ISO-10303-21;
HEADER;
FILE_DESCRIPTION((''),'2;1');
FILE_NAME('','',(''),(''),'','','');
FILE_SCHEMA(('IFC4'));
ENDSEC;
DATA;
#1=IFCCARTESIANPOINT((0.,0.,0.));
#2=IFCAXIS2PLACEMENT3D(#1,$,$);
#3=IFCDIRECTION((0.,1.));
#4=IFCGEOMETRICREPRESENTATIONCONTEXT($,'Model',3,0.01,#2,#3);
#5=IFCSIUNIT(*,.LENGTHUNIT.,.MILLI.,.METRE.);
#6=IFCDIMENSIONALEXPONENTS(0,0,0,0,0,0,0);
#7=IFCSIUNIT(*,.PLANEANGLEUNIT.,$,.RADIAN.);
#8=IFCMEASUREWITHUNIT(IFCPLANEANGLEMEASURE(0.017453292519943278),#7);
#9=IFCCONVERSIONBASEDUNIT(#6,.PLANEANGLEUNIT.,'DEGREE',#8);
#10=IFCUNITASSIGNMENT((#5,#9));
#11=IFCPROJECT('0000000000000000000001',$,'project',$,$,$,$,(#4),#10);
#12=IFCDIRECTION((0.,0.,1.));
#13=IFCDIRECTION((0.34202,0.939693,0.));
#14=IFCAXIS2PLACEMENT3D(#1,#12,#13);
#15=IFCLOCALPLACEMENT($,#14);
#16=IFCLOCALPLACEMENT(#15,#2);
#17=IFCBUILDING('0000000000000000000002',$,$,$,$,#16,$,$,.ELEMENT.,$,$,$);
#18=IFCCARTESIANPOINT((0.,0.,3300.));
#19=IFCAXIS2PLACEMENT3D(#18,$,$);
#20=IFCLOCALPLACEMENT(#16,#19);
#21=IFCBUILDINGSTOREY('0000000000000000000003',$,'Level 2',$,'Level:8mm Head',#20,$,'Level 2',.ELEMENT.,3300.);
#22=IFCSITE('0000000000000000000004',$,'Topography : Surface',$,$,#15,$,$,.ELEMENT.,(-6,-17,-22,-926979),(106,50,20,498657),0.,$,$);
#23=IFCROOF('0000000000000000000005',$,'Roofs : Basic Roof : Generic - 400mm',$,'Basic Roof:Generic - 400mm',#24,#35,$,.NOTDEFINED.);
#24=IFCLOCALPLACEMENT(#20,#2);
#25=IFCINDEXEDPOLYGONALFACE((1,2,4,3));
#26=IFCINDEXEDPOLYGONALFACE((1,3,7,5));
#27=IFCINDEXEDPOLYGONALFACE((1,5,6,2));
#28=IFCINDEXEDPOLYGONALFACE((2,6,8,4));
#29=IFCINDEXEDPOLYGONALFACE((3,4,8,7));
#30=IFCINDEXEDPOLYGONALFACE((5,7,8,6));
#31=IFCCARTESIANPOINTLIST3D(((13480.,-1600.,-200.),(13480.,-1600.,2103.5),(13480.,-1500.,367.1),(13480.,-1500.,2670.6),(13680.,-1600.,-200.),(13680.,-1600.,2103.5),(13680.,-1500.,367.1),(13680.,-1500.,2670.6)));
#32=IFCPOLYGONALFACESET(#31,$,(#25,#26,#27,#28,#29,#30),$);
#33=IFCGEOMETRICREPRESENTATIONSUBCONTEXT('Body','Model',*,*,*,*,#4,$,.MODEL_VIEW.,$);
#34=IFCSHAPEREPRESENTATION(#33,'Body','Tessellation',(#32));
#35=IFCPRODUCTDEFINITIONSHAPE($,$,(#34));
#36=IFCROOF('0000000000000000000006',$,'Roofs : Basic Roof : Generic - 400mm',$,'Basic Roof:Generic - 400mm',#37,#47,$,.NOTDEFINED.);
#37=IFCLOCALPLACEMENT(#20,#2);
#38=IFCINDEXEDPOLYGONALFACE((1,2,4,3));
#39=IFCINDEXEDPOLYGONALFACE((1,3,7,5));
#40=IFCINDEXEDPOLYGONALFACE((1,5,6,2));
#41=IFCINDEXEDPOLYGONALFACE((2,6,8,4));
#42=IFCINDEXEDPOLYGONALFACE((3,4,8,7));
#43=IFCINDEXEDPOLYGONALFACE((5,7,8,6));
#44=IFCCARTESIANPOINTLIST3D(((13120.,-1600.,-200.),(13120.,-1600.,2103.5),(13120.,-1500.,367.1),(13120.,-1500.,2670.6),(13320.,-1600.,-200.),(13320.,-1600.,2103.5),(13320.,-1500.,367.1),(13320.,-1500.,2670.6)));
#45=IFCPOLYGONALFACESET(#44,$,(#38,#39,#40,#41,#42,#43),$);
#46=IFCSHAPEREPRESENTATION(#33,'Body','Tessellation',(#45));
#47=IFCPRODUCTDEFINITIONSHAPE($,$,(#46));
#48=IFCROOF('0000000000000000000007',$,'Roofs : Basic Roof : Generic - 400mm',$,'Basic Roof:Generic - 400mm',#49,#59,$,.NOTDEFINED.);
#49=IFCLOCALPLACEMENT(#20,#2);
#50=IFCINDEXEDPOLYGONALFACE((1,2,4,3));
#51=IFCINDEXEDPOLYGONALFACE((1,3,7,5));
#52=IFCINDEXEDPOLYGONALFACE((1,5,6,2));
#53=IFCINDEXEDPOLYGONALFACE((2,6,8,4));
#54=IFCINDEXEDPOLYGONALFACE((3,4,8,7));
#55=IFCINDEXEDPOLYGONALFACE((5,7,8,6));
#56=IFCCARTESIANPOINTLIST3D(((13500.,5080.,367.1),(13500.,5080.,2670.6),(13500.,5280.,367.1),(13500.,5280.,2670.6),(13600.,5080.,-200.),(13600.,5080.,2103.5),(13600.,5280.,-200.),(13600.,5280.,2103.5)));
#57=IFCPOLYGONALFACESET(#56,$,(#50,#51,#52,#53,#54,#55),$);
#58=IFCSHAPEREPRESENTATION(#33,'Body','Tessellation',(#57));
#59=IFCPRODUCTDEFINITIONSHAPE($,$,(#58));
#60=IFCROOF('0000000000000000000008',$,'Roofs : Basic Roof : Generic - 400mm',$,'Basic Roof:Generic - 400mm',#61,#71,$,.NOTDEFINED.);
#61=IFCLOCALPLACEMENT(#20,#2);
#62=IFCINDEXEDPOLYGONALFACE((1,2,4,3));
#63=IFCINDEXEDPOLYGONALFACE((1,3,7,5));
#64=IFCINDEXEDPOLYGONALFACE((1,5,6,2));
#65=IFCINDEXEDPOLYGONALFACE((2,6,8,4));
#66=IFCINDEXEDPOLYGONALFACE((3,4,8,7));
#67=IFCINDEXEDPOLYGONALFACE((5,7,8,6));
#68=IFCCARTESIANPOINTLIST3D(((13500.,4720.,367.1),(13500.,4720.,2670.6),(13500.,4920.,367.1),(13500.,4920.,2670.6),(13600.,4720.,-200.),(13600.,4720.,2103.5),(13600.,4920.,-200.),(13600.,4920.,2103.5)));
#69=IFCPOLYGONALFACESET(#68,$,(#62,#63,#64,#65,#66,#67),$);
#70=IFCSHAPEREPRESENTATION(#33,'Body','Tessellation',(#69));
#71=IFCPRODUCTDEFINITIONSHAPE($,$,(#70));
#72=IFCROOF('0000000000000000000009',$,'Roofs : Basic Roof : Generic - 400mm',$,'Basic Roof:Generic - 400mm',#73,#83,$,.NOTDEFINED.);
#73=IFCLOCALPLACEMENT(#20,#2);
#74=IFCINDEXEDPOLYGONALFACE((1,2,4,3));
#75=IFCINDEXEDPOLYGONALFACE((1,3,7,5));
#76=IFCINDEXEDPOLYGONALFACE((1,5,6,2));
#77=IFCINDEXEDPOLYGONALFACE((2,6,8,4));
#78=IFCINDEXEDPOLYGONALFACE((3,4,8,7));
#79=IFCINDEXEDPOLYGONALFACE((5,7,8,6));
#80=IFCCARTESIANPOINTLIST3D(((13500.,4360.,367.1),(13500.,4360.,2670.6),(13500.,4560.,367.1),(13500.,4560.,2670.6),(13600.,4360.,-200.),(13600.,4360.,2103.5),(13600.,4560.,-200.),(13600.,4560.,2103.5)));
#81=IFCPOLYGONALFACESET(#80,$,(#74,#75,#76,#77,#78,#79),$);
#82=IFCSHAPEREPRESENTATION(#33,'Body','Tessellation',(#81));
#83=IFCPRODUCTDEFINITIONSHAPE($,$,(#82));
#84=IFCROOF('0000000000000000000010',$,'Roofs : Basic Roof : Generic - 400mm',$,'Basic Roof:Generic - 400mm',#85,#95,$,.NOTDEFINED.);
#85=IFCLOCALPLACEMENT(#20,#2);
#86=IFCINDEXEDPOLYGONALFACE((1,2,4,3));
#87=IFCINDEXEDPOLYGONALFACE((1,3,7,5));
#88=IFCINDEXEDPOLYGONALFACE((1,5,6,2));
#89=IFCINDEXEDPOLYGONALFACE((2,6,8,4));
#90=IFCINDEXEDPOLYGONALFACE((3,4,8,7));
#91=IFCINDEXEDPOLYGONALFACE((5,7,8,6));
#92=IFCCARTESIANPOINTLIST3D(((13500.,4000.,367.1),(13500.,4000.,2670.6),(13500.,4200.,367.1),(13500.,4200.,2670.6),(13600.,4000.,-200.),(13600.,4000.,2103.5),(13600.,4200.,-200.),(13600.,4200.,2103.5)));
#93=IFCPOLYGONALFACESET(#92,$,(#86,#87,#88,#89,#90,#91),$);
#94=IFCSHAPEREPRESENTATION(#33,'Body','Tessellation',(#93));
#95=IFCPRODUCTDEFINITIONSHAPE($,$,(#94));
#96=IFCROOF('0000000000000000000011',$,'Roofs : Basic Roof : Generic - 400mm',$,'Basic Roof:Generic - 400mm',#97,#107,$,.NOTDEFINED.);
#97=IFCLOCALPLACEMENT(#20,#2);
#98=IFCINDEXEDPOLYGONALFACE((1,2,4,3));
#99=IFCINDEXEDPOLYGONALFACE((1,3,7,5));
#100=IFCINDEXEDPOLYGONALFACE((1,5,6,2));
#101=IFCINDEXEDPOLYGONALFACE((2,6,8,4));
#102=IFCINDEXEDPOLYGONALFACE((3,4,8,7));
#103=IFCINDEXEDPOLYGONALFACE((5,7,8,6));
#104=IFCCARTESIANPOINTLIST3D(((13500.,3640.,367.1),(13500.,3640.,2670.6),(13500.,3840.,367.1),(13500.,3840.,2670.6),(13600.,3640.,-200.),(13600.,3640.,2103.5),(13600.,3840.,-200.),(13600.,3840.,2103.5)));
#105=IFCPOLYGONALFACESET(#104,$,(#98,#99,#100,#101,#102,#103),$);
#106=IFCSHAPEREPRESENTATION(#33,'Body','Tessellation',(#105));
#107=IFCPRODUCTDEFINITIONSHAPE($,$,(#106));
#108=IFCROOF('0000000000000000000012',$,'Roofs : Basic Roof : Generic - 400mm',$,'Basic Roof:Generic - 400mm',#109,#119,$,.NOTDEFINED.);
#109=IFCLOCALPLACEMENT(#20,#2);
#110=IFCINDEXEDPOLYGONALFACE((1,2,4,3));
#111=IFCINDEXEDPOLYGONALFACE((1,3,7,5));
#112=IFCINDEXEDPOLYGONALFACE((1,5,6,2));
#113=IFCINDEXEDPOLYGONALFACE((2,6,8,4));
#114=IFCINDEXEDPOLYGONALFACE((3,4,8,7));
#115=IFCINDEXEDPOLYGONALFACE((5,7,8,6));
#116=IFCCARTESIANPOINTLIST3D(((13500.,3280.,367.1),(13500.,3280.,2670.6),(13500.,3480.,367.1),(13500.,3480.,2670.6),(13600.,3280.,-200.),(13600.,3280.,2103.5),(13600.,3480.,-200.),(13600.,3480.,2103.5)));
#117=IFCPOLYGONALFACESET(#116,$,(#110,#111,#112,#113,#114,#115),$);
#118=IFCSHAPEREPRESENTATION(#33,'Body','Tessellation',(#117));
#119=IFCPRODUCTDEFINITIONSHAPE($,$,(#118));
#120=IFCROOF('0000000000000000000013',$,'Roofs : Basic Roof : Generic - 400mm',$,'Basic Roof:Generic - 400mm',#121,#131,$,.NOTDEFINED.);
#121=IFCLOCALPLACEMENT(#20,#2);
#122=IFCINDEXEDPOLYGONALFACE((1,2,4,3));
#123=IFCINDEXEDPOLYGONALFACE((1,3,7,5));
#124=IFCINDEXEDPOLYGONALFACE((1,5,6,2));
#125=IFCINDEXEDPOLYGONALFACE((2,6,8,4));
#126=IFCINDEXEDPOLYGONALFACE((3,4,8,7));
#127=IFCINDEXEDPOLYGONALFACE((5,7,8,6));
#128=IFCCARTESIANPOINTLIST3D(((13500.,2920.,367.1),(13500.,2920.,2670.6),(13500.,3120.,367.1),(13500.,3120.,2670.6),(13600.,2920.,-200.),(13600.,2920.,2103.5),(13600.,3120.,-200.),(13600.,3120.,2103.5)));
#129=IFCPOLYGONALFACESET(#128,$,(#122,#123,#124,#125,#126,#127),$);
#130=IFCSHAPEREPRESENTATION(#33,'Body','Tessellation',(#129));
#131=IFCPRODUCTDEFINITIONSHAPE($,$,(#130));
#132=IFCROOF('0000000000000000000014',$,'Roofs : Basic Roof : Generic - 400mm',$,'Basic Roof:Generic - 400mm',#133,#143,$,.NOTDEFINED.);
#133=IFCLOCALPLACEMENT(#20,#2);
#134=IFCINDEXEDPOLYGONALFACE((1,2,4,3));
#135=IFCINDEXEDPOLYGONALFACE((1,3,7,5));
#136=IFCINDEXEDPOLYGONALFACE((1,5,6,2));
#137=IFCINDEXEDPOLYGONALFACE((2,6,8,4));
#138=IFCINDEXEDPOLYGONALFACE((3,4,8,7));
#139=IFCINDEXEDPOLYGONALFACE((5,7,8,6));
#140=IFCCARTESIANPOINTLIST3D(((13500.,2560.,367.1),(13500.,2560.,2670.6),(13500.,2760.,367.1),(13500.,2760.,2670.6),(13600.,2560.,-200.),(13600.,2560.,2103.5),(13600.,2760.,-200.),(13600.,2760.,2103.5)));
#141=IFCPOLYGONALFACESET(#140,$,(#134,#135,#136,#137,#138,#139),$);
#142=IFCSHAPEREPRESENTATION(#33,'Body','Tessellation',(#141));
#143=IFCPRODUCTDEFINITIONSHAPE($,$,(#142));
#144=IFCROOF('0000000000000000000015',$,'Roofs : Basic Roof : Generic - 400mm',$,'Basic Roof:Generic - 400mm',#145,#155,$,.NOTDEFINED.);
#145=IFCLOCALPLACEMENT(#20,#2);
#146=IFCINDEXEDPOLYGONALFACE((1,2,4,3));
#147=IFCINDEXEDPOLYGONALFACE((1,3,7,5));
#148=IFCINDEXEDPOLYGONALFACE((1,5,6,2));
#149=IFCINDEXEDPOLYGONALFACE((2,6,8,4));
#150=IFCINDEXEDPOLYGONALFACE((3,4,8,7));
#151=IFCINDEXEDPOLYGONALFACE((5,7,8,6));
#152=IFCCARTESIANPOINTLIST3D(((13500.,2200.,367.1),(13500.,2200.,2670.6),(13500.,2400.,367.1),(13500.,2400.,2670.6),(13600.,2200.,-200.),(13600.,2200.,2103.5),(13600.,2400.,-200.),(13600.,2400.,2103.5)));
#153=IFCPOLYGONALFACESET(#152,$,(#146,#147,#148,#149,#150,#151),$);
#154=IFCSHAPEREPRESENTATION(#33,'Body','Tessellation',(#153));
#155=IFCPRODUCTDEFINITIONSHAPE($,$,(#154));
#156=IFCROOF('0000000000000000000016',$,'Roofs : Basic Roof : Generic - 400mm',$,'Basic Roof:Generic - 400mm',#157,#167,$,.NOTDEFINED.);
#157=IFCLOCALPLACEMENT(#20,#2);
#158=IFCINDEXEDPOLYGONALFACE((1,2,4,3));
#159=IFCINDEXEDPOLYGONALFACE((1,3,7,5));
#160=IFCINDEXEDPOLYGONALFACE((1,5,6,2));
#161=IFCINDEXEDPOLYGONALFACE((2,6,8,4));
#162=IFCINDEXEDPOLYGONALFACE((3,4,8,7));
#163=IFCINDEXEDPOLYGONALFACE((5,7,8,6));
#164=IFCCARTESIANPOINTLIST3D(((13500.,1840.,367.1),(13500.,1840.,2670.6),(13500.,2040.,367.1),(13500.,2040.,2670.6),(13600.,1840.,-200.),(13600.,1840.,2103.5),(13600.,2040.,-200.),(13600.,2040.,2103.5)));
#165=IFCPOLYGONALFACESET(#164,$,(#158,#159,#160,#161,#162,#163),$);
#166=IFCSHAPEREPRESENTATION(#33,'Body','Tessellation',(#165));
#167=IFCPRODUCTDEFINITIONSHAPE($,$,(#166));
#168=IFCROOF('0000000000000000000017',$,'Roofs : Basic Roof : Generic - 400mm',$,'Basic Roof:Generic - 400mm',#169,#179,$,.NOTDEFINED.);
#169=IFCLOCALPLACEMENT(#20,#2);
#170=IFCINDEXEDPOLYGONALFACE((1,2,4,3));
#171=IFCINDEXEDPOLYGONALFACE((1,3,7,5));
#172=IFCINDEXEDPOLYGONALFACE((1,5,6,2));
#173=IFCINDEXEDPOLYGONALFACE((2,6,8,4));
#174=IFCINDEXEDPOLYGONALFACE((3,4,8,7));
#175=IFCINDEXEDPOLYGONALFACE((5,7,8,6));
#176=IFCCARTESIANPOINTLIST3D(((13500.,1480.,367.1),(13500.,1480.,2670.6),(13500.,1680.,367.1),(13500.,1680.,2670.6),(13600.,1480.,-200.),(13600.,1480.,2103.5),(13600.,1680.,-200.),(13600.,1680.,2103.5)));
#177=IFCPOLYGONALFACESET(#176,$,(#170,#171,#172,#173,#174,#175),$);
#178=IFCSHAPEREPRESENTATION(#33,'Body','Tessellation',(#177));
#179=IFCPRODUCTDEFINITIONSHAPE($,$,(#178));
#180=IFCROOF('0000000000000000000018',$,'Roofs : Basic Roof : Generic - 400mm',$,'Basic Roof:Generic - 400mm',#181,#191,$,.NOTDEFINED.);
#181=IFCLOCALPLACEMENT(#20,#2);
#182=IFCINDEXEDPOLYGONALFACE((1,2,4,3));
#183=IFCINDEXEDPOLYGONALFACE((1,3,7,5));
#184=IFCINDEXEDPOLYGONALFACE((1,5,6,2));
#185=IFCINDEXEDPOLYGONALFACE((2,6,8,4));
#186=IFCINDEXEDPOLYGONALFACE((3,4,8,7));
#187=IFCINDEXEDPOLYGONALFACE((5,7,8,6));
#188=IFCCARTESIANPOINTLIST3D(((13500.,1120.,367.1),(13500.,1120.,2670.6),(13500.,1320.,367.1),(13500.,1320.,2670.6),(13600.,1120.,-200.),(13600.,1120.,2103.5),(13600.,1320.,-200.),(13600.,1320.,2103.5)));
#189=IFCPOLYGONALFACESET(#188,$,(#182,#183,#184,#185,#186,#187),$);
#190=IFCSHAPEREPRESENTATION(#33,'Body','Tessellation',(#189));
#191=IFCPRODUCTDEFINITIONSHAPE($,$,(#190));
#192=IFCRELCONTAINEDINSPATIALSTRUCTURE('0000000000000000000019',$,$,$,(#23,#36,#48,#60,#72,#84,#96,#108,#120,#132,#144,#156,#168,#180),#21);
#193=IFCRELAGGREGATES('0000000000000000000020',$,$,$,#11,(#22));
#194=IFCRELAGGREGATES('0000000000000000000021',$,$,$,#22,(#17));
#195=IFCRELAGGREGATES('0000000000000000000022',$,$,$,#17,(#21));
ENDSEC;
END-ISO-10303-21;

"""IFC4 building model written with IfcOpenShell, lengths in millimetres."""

from ifc_helpers import new_model, entity, si_unit, converted_unit, direction, frame, origin, place, context, subcontext, project, spatial, indexed_curve, outline, extrude, element, save


model = new_model("IFC4")

# Units and contexts
model_context = context("Model", 3, precision=0.01, world=origin(), true_north=direction((0.0, 1.0)))
body_context = subcontext(model_context, "Body", "Model", "MODEL_VIEW")
ifc_project = project(units=[si_unit("LENGTHUNIT", "METRE", prefix="MILLI"), converted_unit("PLANEANGLEUNIT", "DEGREE", entity("IfcPlaneAngleMeasure", 0.017453292519943278), si_unit("PLANEANGLEUNIT", "RADIAN"), dimensions=[0, 0, 0, 0, 0, 0, 0])], contexts=[model_context])

# Site, building, storey
site_placement = place(None, frame((0.0, 0.0, 0.0), z_axis=(0.0, 0.0, 1.0), x_axis=(0.34202, 0.939693, 0.0)))
site = spatial("IfcSite", under=ifc_project, at=site_placement, Name="Topography : Surface", CompositionType="ELEMENT", RefLatitude=(-6, -17, -22, -926979), RefLongitude=(106, 50, 20, 498657), RefElevation=0.0)
building_placement = place(site_placement, origin())
building = spatial("IfcBuilding", under=site, at=building_placement, CompositionType="ELEMENT")
storey_placement = place(building_placement, frame((0.0, 0.0, 3300.0)))
storey = spatial("IfcBuildingStorey", under=building, at=storey_placement, Name="Level 2", ObjectType="Level:8mm Head", LongName="Level 2", CompositionType="ELEMENT", Elevation=3300.0)

# Roofs
for number, where, name in (
    (1, (13480.0, -1600.0, -200.0), "Roofs : Basic Roof : Generic - 400mm"),
    (2, (13120.0, -1600.0, -200.0), "Roofs : Basic Roof : Generic - 400mm"),
):
    element("IfcRoof", number, at=place(storey_placement, frame(where)), inside=storey, Name=name, ObjectType="Basic Roof:Generic - 400mm", PredefinedType="NOTDEFINED", context=body_context, shape_type="SweptSolid", body=[
        extrude(outline(indexed_curve([(100.0, 287.9), (-100.0, 287.9), (-100.0, -287.9), (100.0, -287.9), (100.0, 287.9)], self_intersect=False)), frame((100.0, 50.0, 283.6), z_axis=(0.0, -0.984808, 0.173648), x_axis=(1.0, 0.0, 0.0)), (0.0, 0.984808, 0.173648), 2303.5),
    ])
roof_1_placement = place(storey_placement, frame((13500.0, 5080.0, -200.0)))
element("IfcRoof", 3, at=roof_1_placement, inside=storey, Name="Roofs : Basic Roof : Generic - 400mm", ObjectType="Basic Roof:Generic - 400mm", PredefinedType="NOTDEFINED", context=body_context, shape_type="SweptSolid", body=[
    extrude(outline(indexed_curve([(-287.9, 100.0), (-287.9, -100.0), (287.9, -100.0), (287.9, 100.0), (-287.9, 100.0)], self_intersect=False)), frame((50.0, 100.0, 283.6), z_axis=(0.984808, 0.0, 0.173648), x_axis=(0.173648, 0.0, -0.984808)), (-0.984808, 0.0, 0.173648), 2303.5),
])
roof_2_placement = place(storey_placement, frame((13500.0, 4720.0, -200.0)))
element("IfcRoof", 4, at=roof_2_placement, inside=storey, Name="Roofs : Basic Roof : Generic - 400mm", ObjectType="Basic Roof:Generic - 400mm", PredefinedType="NOTDEFINED", context=body_context, shape_type="SweptSolid", body=[
    extrude(outline(indexed_curve([(-287.9, 100.0), (-287.9, -100.0), (287.9, -100.0), (287.9, 100.0), (-287.9, 100.0)], self_intersect=False)), frame((50.0, 100.0, 283.6), z_axis=(0.984808, 0.0, 0.173648), x_axis=(0.173648, 0.0, -0.984808)), (-0.984808, 0.0, 0.173648), 2303.5),
])
roof_3_placement = place(storey_placement, frame((13500.0, 4360.0, -200.0)))
element("IfcRoof", 5, at=roof_3_placement, inside=storey, Name="Roofs : Basic Roof : Generic - 400mm", ObjectType="Basic Roof:Generic - 400mm", PredefinedType="NOTDEFINED", context=body_context, shape_type="SweptSolid", body=[
    extrude(outline(indexed_curve([(-287.9, 100.0), (-287.9, -100.0), (287.9, -100.0), (287.9, 100.0), (-287.9, 100.0)], self_intersect=False)), frame((50.0, 100.0, 283.6), z_axis=(0.984808, 0.0, 0.173648), x_axis=(0.173648, 0.0, -0.984808)), (-0.984808, 0.0, 0.173648), 2303.5),
])
roof_4_placement = place(storey_placement, frame((13500.0, 4000.0, -200.0)))
element("IfcRoof", 6, at=roof_4_placement, inside=storey, Name="Roofs : Basic Roof : Generic - 400mm", ObjectType="Basic Roof:Generic - 400mm", PredefinedType="NOTDEFINED", context=body_context, shape_type="SweptSolid", body=[
    extrude(outline(indexed_curve([(-287.9, 100.0), (-287.9, -100.0), (287.9, -100.0), (287.9, 100.0), (-287.9, 100.0)], self_intersect=False)), frame((50.0, 100.0, 283.6), z_axis=(0.984808, 0.0, 0.173648), x_axis=(0.173648, 0.0, -0.984808)), (-0.984808, 0.0, 0.173648), 2303.5),
])
for number, where, name in (
    (7, (13500.0, 3640.0, -200.0), "Roofs : Basic Roof : Generic - 400mm"),
    (8, (13500.0, 3280.0, -200.0), "Roofs : Basic Roof : Generic - 400mm"),
    (9, (13500.0, 2920.0, -200.0), "Roofs : Basic Roof : Generic - 400mm"),
):
    element("IfcRoof", number, at=place(storey_placement, frame(where)), inside=storey, Name=name, ObjectType="Basic Roof:Generic - 400mm", PredefinedType="NOTDEFINED", context=body_context, shape_type="SweptSolid", body=[
        extrude(outline(indexed_curve([(-287.9, 100.0), (-287.9, -100.0), (287.9, -100.0), (287.9, 100.0), (-287.9, 100.0)], self_intersect=False)), frame((50.0, 100.0, 283.6), z_axis=(0.984808, 0.0, 0.173648), x_axis=(0.173648, 0.0, -0.984808)), (-0.984808, 0.0, 0.173648), 2303.5),
    ])
roof_5_placement = place(storey_placement, frame((13500.0, 2560.0, -200.0)))
element("IfcRoof", 10, at=roof_5_placement, inside=storey, Name="Roofs : Basic Roof : Generic - 400mm", ObjectType="Basic Roof:Generic - 400mm", PredefinedType="NOTDEFINED", context=body_context, shape_type="SweptSolid", body=[
    extrude(outline(indexed_curve([(-287.9, 100.0), (-287.9, -100.0), (287.9, -100.0), (287.9, 100.0), (-287.9, 100.0)], self_intersect=False)), frame((50.0, 100.0, 283.6), z_axis=(0.984808, 0.0, 0.173648), x_axis=(0.173648, 0.0, -0.984808)), (-0.984808, 0.0, 0.173648), 2303.5),
])
roof_6_placement = place(storey_placement, frame((13500.0, 2200.0, -200.0)))
element("IfcRoof", 11, at=roof_6_placement, inside=storey, Name="Roofs : Basic Roof : Generic - 400mm", ObjectType="Basic Roof:Generic - 400mm", PredefinedType="NOTDEFINED", context=body_context, shape_type="SweptSolid", body=[
    extrude(outline(indexed_curve([(-287.9, 100.0), (-287.9, -100.0), (287.9, -100.0), (287.9, 100.0), (-287.9, 100.0)], self_intersect=False)), frame((50.0, 100.0, 283.6), z_axis=(0.984808, 0.0, 0.173648), x_axis=(0.173648, 0.0, -0.984808)), (-0.984808, 0.0, 0.173648), 2303.5),
])
roof_7_placement = place(storey_placement, frame((13500.0, 1840.0, -200.0)))
element("IfcRoof", 12, at=roof_7_placement, inside=storey, Name="Roofs : Basic Roof : Generic - 400mm", ObjectType="Basic Roof:Generic - 400mm", PredefinedType="NOTDEFINED", context=body_context, shape_type="SweptSolid", body=[
    extrude(outline(indexed_curve([(-287.9, 100.0), (-287.9, -100.0), (287.9, -100.0), (287.9, 100.0), (-287.9, 100.0)], self_intersect=False)), frame((50.0, 100.0, 283.6), z_axis=(0.984808, 0.0, 0.173648), x_axis=(0.173648, 0.0, -0.984808)), (-0.984808, 0.0, 0.173648), 2303.5),
])
roof_8_placement = place(storey_placement, frame((13500.0, 1480.0, -200.0)))
element("IfcRoof", 13, at=roof_8_placement, inside=storey, Name="Roofs : Basic Roof : Generic - 400mm", ObjectType="Basic Roof:Generic - 400mm", PredefinedType="NOTDEFINED", context=body_context, shape_type="SweptSolid", body=[
    extrude(outline(indexed_curve([(-287.9, 100.0), (-287.9, -100.0), (287.9, -100.0), (287.9, 100.0), (-287.9, 100.0)], self_intersect=False)), frame((50.0, 100.0, 283.6), z_axis=(0.984808, 0.0, 0.173648), x_axis=(0.173648, 0.0, -0.984808)), (-0.984808, 0.0, 0.173648), 2303.5),
])
roof_9_placement = place(storey_placement, frame((13500.0, 1120.0, -200.0)))
element("IfcRoof", 14, at=roof_9_placement, inside=storey, Name="Roofs : Basic Roof : Generic - 400mm", ObjectType="Basic Roof:Generic - 400mm", PredefinedType="NOTDEFINED", context=body_context, shape_type="SweptSolid", body=[
    extrude(outline(indexed_curve([(-287.9, 100.0), (-287.9, -100.0), (287.9, -100.0), (287.9, 100.0), (-287.9, 100.0)], self_intersect=False)), frame((50.0, 100.0, 283.6), z_axis=(0.984808, 0.0, 0.173648), x_axis=(0.173648, 0.0, -0.984808)), (-0.984808, 0.0, 0.173648), 2303.5),
])

save(model, "model.ifc")
